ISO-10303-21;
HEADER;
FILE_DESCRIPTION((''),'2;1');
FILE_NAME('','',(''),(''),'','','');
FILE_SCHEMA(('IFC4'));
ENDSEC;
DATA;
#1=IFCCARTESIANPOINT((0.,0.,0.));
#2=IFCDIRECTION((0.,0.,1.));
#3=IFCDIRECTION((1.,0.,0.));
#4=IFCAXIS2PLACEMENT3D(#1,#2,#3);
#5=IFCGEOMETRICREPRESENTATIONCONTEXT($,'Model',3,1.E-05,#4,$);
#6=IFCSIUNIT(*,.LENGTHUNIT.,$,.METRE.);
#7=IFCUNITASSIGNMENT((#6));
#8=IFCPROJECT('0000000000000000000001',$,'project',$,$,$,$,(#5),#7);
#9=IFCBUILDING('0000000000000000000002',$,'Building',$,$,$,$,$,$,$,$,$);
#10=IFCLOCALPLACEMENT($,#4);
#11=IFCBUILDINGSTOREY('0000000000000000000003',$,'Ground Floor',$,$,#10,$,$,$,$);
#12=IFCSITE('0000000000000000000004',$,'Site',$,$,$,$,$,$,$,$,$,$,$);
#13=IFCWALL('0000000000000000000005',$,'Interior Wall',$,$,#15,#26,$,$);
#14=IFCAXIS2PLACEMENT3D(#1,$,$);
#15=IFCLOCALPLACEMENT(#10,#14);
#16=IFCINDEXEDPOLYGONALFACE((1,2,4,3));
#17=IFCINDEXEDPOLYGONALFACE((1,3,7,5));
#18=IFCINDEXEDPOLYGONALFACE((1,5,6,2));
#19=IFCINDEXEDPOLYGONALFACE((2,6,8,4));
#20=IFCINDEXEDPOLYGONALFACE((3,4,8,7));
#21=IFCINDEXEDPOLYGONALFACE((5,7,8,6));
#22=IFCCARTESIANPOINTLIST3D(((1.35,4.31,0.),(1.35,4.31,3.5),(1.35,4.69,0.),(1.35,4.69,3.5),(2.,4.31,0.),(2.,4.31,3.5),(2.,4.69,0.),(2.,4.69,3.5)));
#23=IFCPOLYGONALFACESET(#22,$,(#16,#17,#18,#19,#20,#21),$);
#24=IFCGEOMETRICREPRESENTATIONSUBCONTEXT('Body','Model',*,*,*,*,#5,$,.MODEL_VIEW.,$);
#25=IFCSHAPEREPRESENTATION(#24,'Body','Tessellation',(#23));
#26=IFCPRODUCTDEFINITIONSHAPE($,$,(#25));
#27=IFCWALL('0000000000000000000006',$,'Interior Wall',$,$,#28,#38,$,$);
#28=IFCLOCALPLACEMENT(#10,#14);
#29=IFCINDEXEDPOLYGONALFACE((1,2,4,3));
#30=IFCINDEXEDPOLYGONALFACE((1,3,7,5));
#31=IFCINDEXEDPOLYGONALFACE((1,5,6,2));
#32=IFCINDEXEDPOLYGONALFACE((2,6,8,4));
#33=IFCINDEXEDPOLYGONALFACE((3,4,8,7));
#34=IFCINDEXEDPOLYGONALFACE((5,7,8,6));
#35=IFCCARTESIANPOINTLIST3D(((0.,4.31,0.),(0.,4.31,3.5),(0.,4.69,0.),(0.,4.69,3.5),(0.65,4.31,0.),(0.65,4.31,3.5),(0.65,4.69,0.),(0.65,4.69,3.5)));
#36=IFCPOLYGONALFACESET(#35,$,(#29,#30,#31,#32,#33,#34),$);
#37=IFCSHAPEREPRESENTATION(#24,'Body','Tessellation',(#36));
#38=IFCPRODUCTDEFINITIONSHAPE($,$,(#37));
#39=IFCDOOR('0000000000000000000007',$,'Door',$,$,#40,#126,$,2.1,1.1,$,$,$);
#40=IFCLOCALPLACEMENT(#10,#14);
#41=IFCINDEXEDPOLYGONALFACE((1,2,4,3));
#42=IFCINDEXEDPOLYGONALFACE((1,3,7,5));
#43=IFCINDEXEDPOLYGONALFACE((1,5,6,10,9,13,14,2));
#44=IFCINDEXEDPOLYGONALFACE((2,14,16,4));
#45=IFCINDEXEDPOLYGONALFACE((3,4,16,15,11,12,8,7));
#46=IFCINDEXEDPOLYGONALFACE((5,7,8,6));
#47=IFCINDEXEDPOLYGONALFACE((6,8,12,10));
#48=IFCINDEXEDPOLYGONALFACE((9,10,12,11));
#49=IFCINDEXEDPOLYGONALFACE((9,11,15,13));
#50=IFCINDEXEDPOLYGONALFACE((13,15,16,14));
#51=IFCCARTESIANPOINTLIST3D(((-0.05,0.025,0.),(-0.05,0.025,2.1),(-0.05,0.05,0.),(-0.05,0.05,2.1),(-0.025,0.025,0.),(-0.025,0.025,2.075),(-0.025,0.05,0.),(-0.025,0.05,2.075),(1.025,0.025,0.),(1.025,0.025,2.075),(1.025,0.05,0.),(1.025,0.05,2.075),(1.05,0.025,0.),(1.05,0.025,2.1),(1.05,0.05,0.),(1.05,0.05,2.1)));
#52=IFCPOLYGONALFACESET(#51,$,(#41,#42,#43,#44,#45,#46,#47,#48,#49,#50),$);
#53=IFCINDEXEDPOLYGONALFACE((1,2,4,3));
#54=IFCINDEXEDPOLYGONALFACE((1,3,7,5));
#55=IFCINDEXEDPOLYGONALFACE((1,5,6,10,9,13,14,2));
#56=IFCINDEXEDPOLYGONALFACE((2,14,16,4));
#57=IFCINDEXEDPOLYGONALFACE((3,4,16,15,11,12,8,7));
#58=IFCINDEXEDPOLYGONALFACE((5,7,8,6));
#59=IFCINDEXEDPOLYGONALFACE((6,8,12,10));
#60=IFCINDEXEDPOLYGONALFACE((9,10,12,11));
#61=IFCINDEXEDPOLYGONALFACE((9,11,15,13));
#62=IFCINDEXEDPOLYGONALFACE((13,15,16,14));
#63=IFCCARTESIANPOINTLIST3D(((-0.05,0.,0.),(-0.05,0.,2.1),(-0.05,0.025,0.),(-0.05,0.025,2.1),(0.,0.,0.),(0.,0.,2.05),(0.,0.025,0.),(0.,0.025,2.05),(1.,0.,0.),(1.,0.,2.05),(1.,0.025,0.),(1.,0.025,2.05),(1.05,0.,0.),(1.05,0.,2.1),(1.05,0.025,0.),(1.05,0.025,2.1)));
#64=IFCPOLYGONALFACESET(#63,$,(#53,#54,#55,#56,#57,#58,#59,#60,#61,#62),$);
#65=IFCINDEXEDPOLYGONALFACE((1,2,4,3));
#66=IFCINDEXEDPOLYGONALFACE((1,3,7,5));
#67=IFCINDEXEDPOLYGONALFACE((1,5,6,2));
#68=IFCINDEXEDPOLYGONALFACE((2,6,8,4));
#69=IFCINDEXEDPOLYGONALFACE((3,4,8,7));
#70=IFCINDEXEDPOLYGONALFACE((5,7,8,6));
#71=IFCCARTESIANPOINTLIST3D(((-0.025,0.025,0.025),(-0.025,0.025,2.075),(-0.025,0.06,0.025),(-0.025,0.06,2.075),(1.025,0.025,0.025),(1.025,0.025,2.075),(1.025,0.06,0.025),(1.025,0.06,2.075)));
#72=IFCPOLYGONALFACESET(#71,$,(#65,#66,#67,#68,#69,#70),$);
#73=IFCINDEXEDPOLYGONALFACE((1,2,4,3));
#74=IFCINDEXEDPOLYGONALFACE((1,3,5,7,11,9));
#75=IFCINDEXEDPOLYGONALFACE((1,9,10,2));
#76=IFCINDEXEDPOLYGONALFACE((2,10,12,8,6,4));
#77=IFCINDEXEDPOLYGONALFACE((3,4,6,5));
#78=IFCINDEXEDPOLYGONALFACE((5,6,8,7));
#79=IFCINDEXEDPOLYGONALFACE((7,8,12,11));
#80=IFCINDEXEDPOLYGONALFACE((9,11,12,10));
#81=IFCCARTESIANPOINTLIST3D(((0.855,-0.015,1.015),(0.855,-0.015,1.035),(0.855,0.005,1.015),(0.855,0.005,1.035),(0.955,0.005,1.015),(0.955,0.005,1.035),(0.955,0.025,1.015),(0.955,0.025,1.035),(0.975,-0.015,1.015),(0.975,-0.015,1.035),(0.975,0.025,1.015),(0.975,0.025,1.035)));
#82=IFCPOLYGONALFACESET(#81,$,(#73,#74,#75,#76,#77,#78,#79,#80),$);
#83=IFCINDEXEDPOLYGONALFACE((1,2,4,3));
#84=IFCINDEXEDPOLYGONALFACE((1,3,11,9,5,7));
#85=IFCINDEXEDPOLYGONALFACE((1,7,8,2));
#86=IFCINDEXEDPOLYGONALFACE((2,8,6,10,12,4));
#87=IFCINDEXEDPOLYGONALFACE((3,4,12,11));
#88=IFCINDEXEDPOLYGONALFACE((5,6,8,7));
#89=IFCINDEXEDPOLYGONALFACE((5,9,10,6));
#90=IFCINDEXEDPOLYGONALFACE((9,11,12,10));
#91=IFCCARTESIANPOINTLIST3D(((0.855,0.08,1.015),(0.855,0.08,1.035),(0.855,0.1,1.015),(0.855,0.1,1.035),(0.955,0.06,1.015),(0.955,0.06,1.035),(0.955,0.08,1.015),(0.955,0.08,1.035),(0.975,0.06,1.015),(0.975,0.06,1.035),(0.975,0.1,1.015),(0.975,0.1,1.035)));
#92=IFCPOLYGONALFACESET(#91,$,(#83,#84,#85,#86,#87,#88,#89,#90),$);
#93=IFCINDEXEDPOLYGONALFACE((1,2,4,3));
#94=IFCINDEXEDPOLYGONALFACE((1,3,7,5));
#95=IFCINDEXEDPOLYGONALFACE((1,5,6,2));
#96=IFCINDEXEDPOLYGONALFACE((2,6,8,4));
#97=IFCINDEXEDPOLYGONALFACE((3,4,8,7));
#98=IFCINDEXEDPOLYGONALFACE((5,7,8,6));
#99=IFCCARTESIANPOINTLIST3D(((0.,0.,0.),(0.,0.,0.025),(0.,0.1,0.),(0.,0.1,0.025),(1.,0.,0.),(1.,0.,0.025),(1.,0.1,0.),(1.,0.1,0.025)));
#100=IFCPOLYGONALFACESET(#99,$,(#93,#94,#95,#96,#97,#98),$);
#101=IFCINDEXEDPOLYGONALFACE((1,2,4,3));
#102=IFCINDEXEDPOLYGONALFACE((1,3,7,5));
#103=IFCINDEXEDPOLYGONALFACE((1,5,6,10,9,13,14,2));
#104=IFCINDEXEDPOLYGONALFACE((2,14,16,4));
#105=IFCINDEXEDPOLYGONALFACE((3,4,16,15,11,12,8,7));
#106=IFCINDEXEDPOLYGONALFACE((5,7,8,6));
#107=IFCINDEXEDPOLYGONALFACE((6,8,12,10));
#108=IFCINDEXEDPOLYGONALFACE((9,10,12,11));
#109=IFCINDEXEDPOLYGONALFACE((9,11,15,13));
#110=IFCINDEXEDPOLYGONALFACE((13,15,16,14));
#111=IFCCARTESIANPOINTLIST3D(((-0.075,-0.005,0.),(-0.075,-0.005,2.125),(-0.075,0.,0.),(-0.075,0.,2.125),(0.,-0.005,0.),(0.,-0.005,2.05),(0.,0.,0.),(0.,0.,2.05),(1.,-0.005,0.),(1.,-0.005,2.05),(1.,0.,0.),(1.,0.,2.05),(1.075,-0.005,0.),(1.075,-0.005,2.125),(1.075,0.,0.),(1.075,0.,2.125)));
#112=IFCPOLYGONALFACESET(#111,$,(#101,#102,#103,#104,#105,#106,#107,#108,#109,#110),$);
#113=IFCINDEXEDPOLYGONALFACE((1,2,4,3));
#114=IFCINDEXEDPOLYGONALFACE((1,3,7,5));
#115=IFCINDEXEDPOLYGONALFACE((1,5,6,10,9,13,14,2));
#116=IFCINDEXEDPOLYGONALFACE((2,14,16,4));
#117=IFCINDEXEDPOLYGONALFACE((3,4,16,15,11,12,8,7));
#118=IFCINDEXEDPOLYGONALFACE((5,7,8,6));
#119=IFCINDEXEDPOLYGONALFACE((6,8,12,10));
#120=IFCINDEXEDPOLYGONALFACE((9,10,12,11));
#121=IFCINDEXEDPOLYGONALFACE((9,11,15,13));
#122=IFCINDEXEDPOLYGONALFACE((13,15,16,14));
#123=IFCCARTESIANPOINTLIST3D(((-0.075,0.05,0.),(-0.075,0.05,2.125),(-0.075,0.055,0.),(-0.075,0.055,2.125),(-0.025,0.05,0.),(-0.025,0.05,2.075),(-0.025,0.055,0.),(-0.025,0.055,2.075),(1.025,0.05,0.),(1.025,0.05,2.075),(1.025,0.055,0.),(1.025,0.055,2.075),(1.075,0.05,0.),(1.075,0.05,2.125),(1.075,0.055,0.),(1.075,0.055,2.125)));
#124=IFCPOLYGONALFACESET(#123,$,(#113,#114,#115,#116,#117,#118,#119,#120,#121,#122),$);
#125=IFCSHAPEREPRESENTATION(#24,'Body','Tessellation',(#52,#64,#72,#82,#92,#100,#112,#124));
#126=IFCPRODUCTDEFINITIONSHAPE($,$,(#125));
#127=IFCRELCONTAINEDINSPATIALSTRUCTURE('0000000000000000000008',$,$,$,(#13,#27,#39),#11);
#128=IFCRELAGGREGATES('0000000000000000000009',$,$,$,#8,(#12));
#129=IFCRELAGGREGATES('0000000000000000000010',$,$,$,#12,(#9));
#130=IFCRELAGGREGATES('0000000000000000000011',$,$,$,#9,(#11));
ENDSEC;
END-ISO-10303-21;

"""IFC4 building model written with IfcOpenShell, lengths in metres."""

from ifc_helpers import new_model, si_unit, frame, origin_with_axes, place, context, subcontext, project, spatial, line, indexed_curve, outline, extrude, element, save


model = new_model("IFC4")

# Units and contexts
model_context = context("Model", 3, precision=1e-05, world=origin_with_axes())
body_context = subcontext(model_context, "Body", "Model", "MODEL_VIEW")
ifc_project = project(units=[si_unit("LENGTHUNIT", "METRE")], contexts=[model_context])

# Site, building, storey
site = spatial("IfcSite", under=ifc_project, Name="Site")
building = spatial("IfcBuilding", under=site, Name="Building")
storey_placement = place(None, origin_with_axes())
storey = spatial("IfcBuildingStorey", under=building, at=storey_placement, Name="Ground Floor")

# Walls
for number, where, z_axis, x_axis, name in (
    (1, (2.0, 4.5, 0.0), (0.0, 0.0, 1.0), (-1.0, 0.0, 0.0), "Interior Wall"),
    (2, (0.65, 4.5, 0.0), (0.0, 0.0, 1.0), (-1.0, 0.0, 0.0), "Interior Wall"),
):
    element("IfcWall", number, at=place(storey_placement, frame(where, z_axis=z_axis, x_axis=x_axis)), inside=storey, Name=name, context=body_context, shape_type="SweptSolid", body=[
        extrude(outline(indexed_curve([(0.0, 0.0), (0.0, 0.38), (0.65, 0.38), (0.65, 0.0), (0.0, 0.0)], self_intersect=False)), frame((0.0, -0.19, 0.0), z_axis=(0.0, 0.0, 1.0), x_axis=(1.0, 0.0, 0.0)), (0.0, 0.0, 1.0), 3.5),
    ])

# Door
door_1_placement = place(storey_placement, frame((-0.05, 0.0, 0.0), z_axis=(0.0, 0.0, 1.0), x_axis=(1.0, 0.0, 0.0)))
element("IfcDoor", 3, at=door_1_placement, inside=storey, Name="Door", OverallHeight=2.1, OverallWidth=1.1, context=body_context, shape_type="SweptSolid", body=[
    extrude(outline(indexed_curve([(0.0, 0.0), (0.0, 2.1), (1.1, 2.1), (1.1, 0.0), (1.075, 0.0), (1.075, 2.075), (0.025, 2.075), (0.025, 0.0)], segments=[line(1, 2, 3, 4, 5, 6, 7, 8, 1)])), frame((0.0, 0.025, 0.0), z_axis=(0.0, -1.0, 0.0), x_axis=(1.0, 0.0, 0.0)), (0.0, 0.0, -1.0), 0.025),
    extrude(outline(indexed_curve([(0.0, 0.0), (0.0, 2.1), (1.1, 2.1), (1.1, 0.0), (1.05, 0.0), (1.05, 2.05), (0.05, 2.05), (0.05, 0.0)], segments=[line(1, 2, 3, 4, 5, 6, 7, 8, 1)])), frame((0.0, 0.0, 0.0), z_axis=(0.0, -1.0, 0.0), x_axis=(1.0, 0.0, 0.0)), (0.0, 0.0, -1.0), 0.025),
    extrude(outline(indexed_curve([(0.0, 0.0), (1.05, 0.0), (1.05, 0.035), (0.0, 0.035)], segments=[line(1, 2, 3, 4, 1)])), frame((0.025, 0.025, 0.025), z_axis=(0.0, 0.0, 1.0), x_axis=(1.0, 0.0, 0.0)), (0.0, 0.0, 1.0), 2.05),
    extrude(outline(indexed_curve([(0.0, 0.0), (0.0, -0.04), (-0.12, -0.04), (-0.12, -0.02), (-0.02, -0.02), (-0.02, 0.0)], segments=[line(1, 2, 3, 4, 5, 6, 1)])), frame((1.025, 0.025, 1.015), z_axis=(0.0, 0.0, 1.0), x_axis=(1.0, 0.0, 0.0)), (0.0, 0.0, 1.0), 0.02),
    extrude(outline(indexed_curve([(0.0, 0.0), (0.0, 0.04), (-0.12, 0.04), (-0.12, 0.02), (-0.02, 0.02), (-0.02, 0.0)], segments=[line(1, 2, 3, 4, 5, 6, 1)])), frame((1.025, 0.06, 1.015), z_axis=(0.0, 0.0, 1.0), x_axis=(1.0, 0.0, 0.0)), (0.0, 0.0, 1.0), 0.02),
    extrude(outline(indexed_curve([(0.0, 0.0), (1.0, 0.0), (1.0, 0.1), (0.0, 0.1)], segments=[line(1, 2, 3, 4, 1)])), frame((0.05, 0.0, 0.0), z_axis=(0.0, 0.0, 1.0), x_axis=(1.0, 0.0, 0.0)), (0.0, 0.0, 1.0), 0.025),
    extrude(outline(indexed_curve([(0.0, 0.0), (0.0, 2.125), (1.15, 2.125), (1.15, 0.0), (1.075, 0.0), (1.075, 2.05), (0.075, 2.05), (0.075, 0.0)], segments=[line(1, 2, 3, 4, 5, 6, 7, 8, 1)])), frame((-0.025, -0.005, 0.0), z_axis=(0.0, -1.0, 0.0), x_axis=(1.0, 0.0, 0.0)), (0.0, 0.0, -1.0), 0.005),
    extrude(outline(indexed_curve([(0.0, 0.0), (0.0, 2.125), (1.15, 2.125), (1.15, 0.0), (1.1, 0.0), (1.1, 2.075), (0.05, 2.075), (0.05, 0.0)], segments=[line(1, 2, 3, 4, 5, 6, 7, 8, 1)])), frame((-0.025, 0.05, 0.0), z_axis=(0.0, -1.0, 0.0), x_axis=(1.0, 0.0, 0.0)), (0.0, 0.0, -1.0), 0.005),
])

save(model, "model.ifc")
